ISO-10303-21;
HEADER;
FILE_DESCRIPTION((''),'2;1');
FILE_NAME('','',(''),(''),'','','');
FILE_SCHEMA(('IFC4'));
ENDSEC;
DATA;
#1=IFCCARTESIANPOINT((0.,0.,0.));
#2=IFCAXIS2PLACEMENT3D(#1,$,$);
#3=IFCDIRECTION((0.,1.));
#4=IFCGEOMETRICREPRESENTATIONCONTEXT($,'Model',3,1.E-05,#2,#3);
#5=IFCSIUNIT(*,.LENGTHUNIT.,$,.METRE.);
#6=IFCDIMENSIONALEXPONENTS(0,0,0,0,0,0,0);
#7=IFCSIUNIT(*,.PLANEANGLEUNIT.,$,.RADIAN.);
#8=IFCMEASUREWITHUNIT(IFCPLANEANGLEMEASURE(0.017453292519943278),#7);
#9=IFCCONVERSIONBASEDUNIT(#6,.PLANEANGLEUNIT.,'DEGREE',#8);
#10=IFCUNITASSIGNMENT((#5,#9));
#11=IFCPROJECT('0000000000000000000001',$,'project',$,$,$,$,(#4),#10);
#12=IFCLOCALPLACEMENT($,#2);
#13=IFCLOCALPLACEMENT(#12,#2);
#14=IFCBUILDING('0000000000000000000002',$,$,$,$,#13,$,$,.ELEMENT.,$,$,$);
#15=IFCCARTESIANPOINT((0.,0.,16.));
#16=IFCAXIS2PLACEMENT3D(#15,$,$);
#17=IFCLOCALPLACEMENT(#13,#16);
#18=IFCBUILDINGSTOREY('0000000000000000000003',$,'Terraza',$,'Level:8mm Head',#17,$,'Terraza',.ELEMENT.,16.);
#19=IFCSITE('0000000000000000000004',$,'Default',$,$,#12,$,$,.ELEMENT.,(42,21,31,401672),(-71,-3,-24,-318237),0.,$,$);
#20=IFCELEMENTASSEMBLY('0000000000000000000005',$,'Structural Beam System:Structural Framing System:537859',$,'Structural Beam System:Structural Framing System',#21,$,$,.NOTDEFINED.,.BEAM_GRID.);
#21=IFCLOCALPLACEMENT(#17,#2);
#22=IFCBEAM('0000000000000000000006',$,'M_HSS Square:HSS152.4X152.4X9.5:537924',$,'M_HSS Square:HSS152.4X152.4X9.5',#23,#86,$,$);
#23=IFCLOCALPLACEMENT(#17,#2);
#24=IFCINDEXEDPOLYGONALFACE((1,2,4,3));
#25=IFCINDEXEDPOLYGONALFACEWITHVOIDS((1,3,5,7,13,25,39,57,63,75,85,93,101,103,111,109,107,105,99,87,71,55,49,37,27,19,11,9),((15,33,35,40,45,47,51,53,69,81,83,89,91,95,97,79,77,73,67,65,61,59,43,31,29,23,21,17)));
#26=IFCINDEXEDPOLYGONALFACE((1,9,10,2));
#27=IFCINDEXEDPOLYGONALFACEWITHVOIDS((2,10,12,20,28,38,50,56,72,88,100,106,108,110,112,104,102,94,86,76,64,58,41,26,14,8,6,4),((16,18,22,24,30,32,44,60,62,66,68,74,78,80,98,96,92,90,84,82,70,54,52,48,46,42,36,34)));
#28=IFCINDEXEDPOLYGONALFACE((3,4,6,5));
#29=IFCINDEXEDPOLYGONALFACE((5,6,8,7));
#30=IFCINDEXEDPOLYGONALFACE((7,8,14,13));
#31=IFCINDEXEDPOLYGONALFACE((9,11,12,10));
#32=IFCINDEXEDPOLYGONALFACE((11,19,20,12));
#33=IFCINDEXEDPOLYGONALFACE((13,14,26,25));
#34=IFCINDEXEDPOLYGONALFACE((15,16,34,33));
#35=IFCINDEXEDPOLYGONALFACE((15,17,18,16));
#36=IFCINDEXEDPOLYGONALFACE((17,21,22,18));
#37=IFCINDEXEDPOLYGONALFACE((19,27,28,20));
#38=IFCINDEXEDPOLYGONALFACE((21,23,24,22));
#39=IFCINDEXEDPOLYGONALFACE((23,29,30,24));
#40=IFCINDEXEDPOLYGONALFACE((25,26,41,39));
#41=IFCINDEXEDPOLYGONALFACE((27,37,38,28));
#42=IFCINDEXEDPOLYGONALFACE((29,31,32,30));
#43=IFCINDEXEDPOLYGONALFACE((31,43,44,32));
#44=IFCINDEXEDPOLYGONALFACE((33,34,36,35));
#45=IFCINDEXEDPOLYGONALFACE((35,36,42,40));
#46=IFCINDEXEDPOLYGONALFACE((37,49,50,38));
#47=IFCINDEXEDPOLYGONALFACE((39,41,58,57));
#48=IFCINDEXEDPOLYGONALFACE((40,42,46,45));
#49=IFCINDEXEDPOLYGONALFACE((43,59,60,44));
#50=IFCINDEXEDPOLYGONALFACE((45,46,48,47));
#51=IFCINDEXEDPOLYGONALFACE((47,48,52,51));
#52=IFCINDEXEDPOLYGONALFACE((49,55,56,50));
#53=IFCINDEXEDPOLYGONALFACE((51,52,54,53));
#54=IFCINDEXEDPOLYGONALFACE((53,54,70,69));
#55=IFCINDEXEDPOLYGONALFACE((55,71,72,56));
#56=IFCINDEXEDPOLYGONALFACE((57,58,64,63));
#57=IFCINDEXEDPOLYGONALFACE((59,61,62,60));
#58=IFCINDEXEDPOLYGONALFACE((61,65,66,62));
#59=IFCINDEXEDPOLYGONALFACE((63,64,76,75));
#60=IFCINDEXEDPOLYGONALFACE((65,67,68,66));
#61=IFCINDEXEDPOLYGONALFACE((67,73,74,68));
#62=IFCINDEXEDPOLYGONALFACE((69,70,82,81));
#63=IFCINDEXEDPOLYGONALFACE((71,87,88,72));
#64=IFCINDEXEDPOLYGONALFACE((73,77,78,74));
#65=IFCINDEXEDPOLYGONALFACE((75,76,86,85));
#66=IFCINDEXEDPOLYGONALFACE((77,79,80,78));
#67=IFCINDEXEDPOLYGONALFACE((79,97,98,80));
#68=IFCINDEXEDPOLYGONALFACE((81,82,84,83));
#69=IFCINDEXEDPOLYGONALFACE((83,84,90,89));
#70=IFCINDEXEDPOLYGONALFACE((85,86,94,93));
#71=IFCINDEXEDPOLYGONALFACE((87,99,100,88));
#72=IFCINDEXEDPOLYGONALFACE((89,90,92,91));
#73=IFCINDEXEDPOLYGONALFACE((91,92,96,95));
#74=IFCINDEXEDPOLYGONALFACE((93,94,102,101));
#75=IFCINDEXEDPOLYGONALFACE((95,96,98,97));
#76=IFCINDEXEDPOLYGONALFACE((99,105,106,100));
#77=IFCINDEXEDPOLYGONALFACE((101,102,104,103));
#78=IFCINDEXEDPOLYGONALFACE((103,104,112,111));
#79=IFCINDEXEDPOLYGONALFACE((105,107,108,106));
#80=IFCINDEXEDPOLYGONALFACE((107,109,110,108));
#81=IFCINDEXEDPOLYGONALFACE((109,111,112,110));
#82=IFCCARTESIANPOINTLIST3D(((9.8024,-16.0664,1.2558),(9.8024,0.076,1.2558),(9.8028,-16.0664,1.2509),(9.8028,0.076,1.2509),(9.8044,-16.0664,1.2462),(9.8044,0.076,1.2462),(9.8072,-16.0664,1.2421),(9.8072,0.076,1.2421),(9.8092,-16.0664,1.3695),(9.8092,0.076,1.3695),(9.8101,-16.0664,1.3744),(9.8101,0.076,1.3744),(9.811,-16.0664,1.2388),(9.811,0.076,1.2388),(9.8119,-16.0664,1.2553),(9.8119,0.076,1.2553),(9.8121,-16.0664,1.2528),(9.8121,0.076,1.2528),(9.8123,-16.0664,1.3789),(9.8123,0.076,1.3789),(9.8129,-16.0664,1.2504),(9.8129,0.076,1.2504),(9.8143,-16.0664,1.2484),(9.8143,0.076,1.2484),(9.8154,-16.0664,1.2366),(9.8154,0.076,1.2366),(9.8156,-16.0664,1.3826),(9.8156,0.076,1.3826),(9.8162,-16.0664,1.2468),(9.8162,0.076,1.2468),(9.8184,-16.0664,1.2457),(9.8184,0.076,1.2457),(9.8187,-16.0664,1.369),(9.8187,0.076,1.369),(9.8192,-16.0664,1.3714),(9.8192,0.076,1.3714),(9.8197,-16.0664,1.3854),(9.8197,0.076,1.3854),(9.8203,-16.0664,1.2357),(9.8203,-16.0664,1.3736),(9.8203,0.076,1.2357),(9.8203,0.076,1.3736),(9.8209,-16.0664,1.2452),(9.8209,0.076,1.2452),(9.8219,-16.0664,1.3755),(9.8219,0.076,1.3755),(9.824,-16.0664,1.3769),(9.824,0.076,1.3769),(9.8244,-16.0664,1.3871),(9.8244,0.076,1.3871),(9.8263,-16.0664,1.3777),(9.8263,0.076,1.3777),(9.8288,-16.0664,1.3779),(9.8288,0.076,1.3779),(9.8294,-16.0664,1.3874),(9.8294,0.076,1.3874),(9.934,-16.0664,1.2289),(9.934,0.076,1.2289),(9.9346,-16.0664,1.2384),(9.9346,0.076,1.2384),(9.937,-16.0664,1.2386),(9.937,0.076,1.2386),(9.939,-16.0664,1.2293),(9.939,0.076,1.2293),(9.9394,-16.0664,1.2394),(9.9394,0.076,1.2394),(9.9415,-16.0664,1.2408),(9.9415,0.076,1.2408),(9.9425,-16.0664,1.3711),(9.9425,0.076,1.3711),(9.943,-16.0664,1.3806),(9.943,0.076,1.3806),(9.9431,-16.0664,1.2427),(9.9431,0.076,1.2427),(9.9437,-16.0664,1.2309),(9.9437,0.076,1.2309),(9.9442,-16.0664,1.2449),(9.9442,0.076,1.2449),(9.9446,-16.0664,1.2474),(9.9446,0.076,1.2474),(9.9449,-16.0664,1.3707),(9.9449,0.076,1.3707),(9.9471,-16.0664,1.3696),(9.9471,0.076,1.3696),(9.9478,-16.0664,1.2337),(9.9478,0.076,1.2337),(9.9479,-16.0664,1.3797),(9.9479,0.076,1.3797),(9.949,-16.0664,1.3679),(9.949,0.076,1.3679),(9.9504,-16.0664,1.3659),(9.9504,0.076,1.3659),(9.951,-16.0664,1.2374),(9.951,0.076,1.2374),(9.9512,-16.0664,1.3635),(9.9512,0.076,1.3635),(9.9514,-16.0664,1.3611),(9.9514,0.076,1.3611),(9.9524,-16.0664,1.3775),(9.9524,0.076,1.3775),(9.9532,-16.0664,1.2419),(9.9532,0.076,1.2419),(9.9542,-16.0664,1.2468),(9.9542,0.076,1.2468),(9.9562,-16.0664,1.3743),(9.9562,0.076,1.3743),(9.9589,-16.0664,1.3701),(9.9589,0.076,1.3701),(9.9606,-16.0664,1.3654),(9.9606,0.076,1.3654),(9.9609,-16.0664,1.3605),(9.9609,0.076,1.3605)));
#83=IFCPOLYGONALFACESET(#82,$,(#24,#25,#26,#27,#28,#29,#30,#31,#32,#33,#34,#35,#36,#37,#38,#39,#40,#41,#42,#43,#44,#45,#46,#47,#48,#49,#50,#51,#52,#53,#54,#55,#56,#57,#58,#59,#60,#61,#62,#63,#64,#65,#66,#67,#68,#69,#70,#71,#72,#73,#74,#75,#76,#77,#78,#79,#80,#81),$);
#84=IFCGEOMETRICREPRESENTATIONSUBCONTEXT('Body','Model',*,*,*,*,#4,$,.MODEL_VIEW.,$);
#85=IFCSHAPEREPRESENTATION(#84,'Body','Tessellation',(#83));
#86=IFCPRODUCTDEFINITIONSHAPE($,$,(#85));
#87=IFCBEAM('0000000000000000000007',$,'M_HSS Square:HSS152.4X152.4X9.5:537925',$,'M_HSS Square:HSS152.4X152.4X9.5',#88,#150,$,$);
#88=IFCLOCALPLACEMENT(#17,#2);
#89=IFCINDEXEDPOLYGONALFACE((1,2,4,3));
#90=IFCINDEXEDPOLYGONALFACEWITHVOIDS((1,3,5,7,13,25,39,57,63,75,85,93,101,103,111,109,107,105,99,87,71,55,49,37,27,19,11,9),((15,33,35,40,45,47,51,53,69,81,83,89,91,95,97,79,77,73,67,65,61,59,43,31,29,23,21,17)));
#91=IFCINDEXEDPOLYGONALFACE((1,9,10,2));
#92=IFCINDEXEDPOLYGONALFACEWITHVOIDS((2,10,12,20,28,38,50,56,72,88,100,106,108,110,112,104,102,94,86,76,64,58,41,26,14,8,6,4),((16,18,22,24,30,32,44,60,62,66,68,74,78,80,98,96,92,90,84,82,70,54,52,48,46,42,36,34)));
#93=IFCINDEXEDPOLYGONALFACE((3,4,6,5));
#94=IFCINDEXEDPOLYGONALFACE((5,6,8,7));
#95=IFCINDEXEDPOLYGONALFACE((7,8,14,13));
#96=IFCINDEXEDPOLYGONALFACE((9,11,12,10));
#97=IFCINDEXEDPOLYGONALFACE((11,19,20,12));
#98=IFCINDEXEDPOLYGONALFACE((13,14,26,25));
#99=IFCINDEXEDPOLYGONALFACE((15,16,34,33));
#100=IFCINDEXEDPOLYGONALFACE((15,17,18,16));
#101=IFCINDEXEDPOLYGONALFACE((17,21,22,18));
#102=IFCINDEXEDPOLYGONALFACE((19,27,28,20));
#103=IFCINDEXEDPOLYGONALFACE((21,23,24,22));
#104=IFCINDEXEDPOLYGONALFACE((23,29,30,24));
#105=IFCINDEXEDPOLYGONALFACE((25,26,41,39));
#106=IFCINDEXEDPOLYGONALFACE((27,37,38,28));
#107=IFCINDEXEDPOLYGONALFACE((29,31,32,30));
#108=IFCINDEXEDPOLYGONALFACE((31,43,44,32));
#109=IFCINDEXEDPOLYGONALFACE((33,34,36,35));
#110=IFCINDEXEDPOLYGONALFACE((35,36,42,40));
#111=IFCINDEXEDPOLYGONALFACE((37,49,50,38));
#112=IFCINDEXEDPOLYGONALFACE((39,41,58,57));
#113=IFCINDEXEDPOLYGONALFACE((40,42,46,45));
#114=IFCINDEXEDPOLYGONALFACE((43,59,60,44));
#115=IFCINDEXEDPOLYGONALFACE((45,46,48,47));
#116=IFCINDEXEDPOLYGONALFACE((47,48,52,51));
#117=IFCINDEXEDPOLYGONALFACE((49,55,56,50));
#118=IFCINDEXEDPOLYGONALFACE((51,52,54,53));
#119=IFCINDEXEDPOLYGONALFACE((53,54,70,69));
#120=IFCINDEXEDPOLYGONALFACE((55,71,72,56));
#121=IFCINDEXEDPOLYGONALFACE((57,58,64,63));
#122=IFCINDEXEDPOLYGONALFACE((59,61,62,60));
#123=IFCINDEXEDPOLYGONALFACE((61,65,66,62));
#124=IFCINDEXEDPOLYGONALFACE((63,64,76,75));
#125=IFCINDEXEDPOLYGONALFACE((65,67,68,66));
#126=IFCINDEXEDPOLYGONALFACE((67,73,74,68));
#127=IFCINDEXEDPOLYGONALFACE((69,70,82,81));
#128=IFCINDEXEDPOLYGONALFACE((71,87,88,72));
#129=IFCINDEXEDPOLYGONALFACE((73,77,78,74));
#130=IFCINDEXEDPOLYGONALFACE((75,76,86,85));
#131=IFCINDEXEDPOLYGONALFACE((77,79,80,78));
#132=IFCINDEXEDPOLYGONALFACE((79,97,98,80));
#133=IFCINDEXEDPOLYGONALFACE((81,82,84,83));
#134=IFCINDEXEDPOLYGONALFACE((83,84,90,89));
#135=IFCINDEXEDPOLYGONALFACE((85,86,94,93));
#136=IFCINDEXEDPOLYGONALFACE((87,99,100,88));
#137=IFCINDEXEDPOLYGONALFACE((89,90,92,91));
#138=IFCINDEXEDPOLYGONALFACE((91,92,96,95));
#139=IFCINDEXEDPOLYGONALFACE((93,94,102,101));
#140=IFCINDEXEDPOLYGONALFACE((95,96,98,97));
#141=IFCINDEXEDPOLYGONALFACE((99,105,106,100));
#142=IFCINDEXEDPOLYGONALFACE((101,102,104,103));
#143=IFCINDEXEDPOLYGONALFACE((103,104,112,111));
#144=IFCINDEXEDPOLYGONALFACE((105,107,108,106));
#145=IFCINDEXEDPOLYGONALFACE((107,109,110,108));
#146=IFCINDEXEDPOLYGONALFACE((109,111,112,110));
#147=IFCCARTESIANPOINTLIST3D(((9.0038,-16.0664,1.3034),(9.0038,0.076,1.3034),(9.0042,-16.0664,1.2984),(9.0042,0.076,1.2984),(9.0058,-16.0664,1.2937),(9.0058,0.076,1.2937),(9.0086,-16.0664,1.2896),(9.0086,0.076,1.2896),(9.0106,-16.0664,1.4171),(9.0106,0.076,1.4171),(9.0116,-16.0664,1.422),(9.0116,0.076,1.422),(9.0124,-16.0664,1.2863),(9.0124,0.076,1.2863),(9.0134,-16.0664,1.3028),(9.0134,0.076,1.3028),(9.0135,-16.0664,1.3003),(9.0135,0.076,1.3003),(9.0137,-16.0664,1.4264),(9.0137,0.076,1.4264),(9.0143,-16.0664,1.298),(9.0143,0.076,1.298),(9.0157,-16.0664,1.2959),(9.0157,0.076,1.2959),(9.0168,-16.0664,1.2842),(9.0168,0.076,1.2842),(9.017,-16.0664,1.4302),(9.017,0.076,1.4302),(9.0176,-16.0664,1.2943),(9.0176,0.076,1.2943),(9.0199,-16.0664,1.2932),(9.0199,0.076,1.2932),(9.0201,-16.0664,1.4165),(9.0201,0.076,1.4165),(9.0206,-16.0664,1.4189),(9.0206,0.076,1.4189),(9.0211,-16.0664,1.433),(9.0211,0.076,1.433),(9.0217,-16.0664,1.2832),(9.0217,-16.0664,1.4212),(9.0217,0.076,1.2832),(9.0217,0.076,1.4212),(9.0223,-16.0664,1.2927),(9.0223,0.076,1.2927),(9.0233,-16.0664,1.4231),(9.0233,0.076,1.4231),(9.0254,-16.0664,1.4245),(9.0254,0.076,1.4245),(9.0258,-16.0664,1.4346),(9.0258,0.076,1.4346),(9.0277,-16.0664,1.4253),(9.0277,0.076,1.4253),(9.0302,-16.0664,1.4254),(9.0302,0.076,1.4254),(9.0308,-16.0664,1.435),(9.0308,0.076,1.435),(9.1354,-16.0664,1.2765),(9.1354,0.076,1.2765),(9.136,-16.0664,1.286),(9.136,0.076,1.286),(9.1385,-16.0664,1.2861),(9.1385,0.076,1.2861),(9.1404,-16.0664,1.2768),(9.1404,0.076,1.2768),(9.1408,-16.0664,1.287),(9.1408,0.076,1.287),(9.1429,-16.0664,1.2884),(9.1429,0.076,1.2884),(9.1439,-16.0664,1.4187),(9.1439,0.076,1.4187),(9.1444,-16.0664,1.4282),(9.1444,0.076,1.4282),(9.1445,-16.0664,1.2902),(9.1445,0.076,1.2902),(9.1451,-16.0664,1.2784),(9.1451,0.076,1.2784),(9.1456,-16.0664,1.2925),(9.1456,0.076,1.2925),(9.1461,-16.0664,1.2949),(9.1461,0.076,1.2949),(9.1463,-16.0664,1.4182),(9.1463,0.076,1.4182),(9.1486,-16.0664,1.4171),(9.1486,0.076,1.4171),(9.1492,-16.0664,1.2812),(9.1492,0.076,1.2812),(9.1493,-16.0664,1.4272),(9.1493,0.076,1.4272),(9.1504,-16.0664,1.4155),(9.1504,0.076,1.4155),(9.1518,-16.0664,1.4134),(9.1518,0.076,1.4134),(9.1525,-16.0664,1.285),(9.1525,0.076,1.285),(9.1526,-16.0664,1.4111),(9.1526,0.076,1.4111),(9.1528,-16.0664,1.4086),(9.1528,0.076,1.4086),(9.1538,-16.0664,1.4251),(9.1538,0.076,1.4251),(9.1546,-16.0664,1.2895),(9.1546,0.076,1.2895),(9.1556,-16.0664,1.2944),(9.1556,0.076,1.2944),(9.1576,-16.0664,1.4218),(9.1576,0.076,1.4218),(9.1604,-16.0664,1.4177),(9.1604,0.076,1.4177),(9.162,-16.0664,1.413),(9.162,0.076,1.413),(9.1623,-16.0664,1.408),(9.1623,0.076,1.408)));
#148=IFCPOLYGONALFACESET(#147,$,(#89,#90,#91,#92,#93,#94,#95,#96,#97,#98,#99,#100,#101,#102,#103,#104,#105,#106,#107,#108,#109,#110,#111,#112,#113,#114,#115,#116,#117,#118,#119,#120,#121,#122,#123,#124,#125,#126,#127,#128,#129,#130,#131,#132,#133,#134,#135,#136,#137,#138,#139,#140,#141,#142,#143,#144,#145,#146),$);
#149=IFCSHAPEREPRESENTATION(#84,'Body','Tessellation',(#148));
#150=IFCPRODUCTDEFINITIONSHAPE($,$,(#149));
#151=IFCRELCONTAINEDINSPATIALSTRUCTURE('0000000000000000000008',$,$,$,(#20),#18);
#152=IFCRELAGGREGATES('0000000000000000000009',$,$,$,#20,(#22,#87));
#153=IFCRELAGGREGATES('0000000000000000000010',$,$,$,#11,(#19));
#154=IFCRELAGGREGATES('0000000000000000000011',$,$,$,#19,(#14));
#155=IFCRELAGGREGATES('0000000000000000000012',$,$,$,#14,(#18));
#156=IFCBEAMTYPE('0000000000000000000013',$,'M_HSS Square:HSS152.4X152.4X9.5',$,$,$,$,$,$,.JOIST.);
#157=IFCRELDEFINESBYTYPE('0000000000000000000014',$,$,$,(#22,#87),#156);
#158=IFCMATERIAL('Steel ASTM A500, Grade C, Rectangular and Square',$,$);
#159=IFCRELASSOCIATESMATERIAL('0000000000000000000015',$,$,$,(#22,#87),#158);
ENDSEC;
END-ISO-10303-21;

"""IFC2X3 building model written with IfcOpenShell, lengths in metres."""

from ifc_helpers import new_model, entity, si_unit, converted_unit, direction, frame, frame_2d, origin, place, context, subcontext, project, spatial, polyline, circle_curve, parameter, trimmed, segment, composite_curve, outline, extrude, material, type_object, element, aggregate, save


model = new_model("IFC2X3")

# Units and contexts
model_context = context("Model", 3, precision=1e-05, world=origin(), true_north=direction((0.0, 1.0)))
body_context = subcontext(model_context, "Body", "Model", "MODEL_VIEW")
ifc_project = project(units=[si_unit("LENGTHUNIT", "METRE"), converted_unit("PLANEANGLEUNIT", "DEGREE", entity("IfcPlaneAngleMeasure", 0.017453292519943278), si_unit("PLANEANGLEUNIT", "RADIAN"), dimensions=[0, 0, 0, 0, 0, 0, 0])], contexts=[model_context])

# Site, building, storey
site_placement = place(None, origin())
site = spatial("IfcSite", under=ifc_project, at=site_placement, Name="Default", CompositionType="ELEMENT", RefLatitude=(42, 21, 31, 401672), RefLongitude=(-71, -3, -24, -318237), RefElevation=0.0)
building_placement = place(site_placement, origin())
building = spatial("IfcBuilding", under=site, at=building_placement, CompositionType="ELEMENT")
storey_placement = place(building_placement, frame((0.0, 0.0, 16.0)))
storey = spatial("IfcBuildingStorey", under=building, at=storey_placement, Name="Terraza", ObjectType="Level:8mm Head", LongName="Terraza", CompositionType="ELEMENT", Elevation=16.0)

# Element assembly, beams
assembly_1_placement = place(storey_placement, origin())
assembly_1 = element("IfcElementAssembly", 1, at=assembly_1_placement, inside=storey, Name="Structural Beam System:Structural Framing System:537859", ObjectType="Structural Beam System:Structural Framing System", AssemblyPlace="NOTDEFINED", PredefinedType="BEAM_GRID")
ifc_material_1 = material(Name="Steel ASTM A500, Grade C, Rectangular and Square")
beam_type = type_object("IfcBeamType", Name="M_HSS Square:HSS152.4X152.4X9.5", PredefinedType="JOIST")
beam_1_placement = place(assembly_1_placement, frame((9.8772, 0.076, 1.2323), z_axis=(0.0, 0.0, 1.0), x_axis=(0.0, -1.0, 0.0)))
beam_1 = element("IfcBeam", 2, at=beam_1_placement, type_object=beam_type, material=ifc_material_1, Name="M_HSS Square:HSS152.4X152.4X9.5:537924", ObjectType="M_HSS Square:HSS152.4X152.4X9.5", context=body_context, shape_type="SweptSolid", body=[
    extrude(outline(composite_curve([segment(polyline([(-0.0569, -0.076), (0.0569, -0.076)]), True, "CONTINUOUS"), segment(trimmed(circle_curve(frame_2d((0.0569, -0.0569), x_axis=(0.0, 1.0)), 0.0191), [parameter(180.0)], [parameter(270.0)], True, "PARAMETER"), True, "CONTINUOUS"), segment(polyline([(0.076, -0.0569), (0.076, 0.0569)]), True, "CONTINUOUS"), segment(trimmed(circle_curve(frame_2d((0.0569, 0.0569), x_axis=(0.0, 1.0)), 0.0191), [parameter(270.0)], [parameter(0.0)], True, "PARAMETER"), True, "CONTINUOUS"), segment(polyline([(0.0569, 0.076), (-0.0569, 0.076)]), True, "CONTINUOUS"), segment(trimmed(circle_curve(frame_2d((-0.0569, 0.0569), x_axis=(0.0, 1.0)), 0.0191), [parameter(0.0)], [parameter(90.0)], True, "PARAMETER"), True, "CONTINUOUS"), segment(polyline([(-0.076, 0.0569), (-0.076, -0.0569)]), True, "CONTINUOUS"), segment(trimmed(circle_curve(frame_2d((-0.0569, -0.0569), x_axis=(0.0, 1.0)), 0.0191), [parameter(90.0)], [parameter(180.0)], True, "PARAMETER"), True, "CONTINUOUS")], self_intersect=False), holes=[composite_curve([segment(trimmed(circle_curve(frame_2d((-0.0569, 0.0569), x_axis=(0.0, 1.0)), 0.0095), [parameter(360.0)], [parameter(90.0)], True, "PARAMETER"), False, "CONTINUOUS"), segment(polyline([(-0.0569, 0.0665), (0.0569, 0.0665)]), True, "CONTINUOUS"), segment(trimmed(circle_curve(frame_2d((0.0569, 0.0569), x_axis=(0.0, 1.0)), 0.0095), [parameter(270.0)], [parameter(360.0)], True, "PARAMETER"), False, "CONTINUOUS"), segment(polyline([(0.0665, 0.0569), (0.0665, -0.0569)]), True, "CONTINUOUS"), segment(trimmed(circle_curve(frame_2d((0.0569, -0.0569), x_axis=(0.0, 1.0)), 0.0095), [parameter(180.0)], [parameter(270.0)], True, "PARAMETER"), False, "CONTINUOUS"), segment(polyline([(0.0569, -0.0665), (-0.0569, -0.0665)]), True, "CONTINUOUS"), segment(trimmed(circle_curve(frame_2d((-0.0569, -0.0569), x_axis=(0.0, 1.0)), 0.0095), [parameter(90.0)], [parameter(180.0)], True, "PARAMETER"), False, "CONTINUOUS"), segment(polyline([(-0.0665, -0.0569), (-0.0665, 0.0569)]), True, "CONTINUOUS")], self_intersect=False)]), frame((0.0, 0.0045, 0.0759), z_axis=(1.0, 0.0, 0.0), x_axis=(0.0, -0.059434, -0.998232)), (0.0, 0.0, 1.0), 16.1424),
])
beam_2_placement = place(assembly_1_placement, frame((9.0786, 0.076, 1.2798), z_axis=(0.0, 0.0, 1.0), x_axis=(0.0, -1.0, 0.0)))
beam_2 = element("IfcBeam", 3, at=beam_2_placement, type_object=beam_type, material=ifc_material_1, Name="M_HSS Square:HSS152.4X152.4X9.5:537925", ObjectType="M_HSS Square:HSS152.4X152.4X9.5", context=body_context, shape_type="SweptSolid", body=[
    extrude(outline(composite_curve([segment(polyline([(-0.0569, -0.076), (0.0569, -0.076)]), True, "CONTINUOUS"), segment(trimmed(circle_curve(frame_2d((0.0569, -0.0569), x_axis=(0.0, 1.0)), 0.0191), [parameter(180.0)], [parameter(270.0)], True, "PARAMETER"), True, "CONTINUOUS"), segment(polyline([(0.076, -0.0569), (0.076, 0.0569)]), True, "CONTINUOUS"), segment(trimmed(circle_curve(frame_2d((0.0569, 0.0569), x_axis=(0.0, 1.0)), 0.0191), [parameter(270.0)], [parameter(0.0)], True, "PARAMETER"), True, "CONTINUOUS"), segment(polyline([(0.0569, 0.076), (-0.0569, 0.076)]), True, "CONTINUOUS"), segment(trimmed(circle_curve(frame_2d((-0.0569, 0.0569), x_axis=(0.0, 1.0)), 0.0191), [parameter(0.0)], [parameter(90.0)], True, "PARAMETER"), True, "CONTINUOUS"), segment(polyline([(-0.076, 0.0569), (-0.076, -0.0569)]), True, "CONTINUOUS"), segment(trimmed(circle_curve(frame_2d((-0.0569, -0.0569), x_axis=(0.0, 1.0)), 0.0191), [parameter(90.0)], [parameter(180.0)], True, "PARAMETER"), True, "CONTINUOUS")], self_intersect=False), holes=[composite_curve([segment(trimmed(circle_curve(frame_2d((-0.0569, 0.0569), x_axis=(0.0, 1.0)), 0.0095), [parameter(360.0)], [parameter(90.0)], True, "PARAMETER"), False, "CONTINUOUS"), segment(polyline([(-0.0569, 0.0665), (0.0569, 0.0665)]), True, "CONTINUOUS"), segment(trimmed(circle_curve(frame_2d((0.0569, 0.0569), x_axis=(0.0, 1.0)), 0.0095), [parameter(270.0)], [parameter(360.0)], True, "PARAMETER"), False, "CONTINUOUS"), segment(polyline([(0.0665, 0.0569), (0.0665, -0.0569)]), True, "CONTINUOUS"), segment(trimmed(circle_curve(frame_2d((0.0569, -0.0569), x_axis=(0.0, 1.0)), 0.0095), [parameter(180.0)], [parameter(270.0)], True, "PARAMETER"), False, "CONTINUOUS"), segment(polyline([(0.0569, -0.0665), (-0.0569, -0.0665)]), True, "CONTINUOUS"), segment(trimmed(circle_curve(frame_2d((-0.0569, -0.0569), x_axis=(0.0, 1.0)), 0.0095), [parameter(90.0)], [parameter(180.0)], True, "PARAMETER"), False, "CONTINUOUS"), segment(polyline([(-0.0665, -0.0569), (-0.0665, 0.0569)]), True, "CONTINUOUS")], self_intersect=False)]), frame((0.0, 0.0045, 0.0759), z_axis=(1.0, 0.0, 0.0), x_axis=(0.0, -0.059434, -0.998232)), (0.0, 0.0, 1.0), 16.1424),
])
aggregate(assembly_1, [beam_1, beam_2])

save(model, "model.ifc")
